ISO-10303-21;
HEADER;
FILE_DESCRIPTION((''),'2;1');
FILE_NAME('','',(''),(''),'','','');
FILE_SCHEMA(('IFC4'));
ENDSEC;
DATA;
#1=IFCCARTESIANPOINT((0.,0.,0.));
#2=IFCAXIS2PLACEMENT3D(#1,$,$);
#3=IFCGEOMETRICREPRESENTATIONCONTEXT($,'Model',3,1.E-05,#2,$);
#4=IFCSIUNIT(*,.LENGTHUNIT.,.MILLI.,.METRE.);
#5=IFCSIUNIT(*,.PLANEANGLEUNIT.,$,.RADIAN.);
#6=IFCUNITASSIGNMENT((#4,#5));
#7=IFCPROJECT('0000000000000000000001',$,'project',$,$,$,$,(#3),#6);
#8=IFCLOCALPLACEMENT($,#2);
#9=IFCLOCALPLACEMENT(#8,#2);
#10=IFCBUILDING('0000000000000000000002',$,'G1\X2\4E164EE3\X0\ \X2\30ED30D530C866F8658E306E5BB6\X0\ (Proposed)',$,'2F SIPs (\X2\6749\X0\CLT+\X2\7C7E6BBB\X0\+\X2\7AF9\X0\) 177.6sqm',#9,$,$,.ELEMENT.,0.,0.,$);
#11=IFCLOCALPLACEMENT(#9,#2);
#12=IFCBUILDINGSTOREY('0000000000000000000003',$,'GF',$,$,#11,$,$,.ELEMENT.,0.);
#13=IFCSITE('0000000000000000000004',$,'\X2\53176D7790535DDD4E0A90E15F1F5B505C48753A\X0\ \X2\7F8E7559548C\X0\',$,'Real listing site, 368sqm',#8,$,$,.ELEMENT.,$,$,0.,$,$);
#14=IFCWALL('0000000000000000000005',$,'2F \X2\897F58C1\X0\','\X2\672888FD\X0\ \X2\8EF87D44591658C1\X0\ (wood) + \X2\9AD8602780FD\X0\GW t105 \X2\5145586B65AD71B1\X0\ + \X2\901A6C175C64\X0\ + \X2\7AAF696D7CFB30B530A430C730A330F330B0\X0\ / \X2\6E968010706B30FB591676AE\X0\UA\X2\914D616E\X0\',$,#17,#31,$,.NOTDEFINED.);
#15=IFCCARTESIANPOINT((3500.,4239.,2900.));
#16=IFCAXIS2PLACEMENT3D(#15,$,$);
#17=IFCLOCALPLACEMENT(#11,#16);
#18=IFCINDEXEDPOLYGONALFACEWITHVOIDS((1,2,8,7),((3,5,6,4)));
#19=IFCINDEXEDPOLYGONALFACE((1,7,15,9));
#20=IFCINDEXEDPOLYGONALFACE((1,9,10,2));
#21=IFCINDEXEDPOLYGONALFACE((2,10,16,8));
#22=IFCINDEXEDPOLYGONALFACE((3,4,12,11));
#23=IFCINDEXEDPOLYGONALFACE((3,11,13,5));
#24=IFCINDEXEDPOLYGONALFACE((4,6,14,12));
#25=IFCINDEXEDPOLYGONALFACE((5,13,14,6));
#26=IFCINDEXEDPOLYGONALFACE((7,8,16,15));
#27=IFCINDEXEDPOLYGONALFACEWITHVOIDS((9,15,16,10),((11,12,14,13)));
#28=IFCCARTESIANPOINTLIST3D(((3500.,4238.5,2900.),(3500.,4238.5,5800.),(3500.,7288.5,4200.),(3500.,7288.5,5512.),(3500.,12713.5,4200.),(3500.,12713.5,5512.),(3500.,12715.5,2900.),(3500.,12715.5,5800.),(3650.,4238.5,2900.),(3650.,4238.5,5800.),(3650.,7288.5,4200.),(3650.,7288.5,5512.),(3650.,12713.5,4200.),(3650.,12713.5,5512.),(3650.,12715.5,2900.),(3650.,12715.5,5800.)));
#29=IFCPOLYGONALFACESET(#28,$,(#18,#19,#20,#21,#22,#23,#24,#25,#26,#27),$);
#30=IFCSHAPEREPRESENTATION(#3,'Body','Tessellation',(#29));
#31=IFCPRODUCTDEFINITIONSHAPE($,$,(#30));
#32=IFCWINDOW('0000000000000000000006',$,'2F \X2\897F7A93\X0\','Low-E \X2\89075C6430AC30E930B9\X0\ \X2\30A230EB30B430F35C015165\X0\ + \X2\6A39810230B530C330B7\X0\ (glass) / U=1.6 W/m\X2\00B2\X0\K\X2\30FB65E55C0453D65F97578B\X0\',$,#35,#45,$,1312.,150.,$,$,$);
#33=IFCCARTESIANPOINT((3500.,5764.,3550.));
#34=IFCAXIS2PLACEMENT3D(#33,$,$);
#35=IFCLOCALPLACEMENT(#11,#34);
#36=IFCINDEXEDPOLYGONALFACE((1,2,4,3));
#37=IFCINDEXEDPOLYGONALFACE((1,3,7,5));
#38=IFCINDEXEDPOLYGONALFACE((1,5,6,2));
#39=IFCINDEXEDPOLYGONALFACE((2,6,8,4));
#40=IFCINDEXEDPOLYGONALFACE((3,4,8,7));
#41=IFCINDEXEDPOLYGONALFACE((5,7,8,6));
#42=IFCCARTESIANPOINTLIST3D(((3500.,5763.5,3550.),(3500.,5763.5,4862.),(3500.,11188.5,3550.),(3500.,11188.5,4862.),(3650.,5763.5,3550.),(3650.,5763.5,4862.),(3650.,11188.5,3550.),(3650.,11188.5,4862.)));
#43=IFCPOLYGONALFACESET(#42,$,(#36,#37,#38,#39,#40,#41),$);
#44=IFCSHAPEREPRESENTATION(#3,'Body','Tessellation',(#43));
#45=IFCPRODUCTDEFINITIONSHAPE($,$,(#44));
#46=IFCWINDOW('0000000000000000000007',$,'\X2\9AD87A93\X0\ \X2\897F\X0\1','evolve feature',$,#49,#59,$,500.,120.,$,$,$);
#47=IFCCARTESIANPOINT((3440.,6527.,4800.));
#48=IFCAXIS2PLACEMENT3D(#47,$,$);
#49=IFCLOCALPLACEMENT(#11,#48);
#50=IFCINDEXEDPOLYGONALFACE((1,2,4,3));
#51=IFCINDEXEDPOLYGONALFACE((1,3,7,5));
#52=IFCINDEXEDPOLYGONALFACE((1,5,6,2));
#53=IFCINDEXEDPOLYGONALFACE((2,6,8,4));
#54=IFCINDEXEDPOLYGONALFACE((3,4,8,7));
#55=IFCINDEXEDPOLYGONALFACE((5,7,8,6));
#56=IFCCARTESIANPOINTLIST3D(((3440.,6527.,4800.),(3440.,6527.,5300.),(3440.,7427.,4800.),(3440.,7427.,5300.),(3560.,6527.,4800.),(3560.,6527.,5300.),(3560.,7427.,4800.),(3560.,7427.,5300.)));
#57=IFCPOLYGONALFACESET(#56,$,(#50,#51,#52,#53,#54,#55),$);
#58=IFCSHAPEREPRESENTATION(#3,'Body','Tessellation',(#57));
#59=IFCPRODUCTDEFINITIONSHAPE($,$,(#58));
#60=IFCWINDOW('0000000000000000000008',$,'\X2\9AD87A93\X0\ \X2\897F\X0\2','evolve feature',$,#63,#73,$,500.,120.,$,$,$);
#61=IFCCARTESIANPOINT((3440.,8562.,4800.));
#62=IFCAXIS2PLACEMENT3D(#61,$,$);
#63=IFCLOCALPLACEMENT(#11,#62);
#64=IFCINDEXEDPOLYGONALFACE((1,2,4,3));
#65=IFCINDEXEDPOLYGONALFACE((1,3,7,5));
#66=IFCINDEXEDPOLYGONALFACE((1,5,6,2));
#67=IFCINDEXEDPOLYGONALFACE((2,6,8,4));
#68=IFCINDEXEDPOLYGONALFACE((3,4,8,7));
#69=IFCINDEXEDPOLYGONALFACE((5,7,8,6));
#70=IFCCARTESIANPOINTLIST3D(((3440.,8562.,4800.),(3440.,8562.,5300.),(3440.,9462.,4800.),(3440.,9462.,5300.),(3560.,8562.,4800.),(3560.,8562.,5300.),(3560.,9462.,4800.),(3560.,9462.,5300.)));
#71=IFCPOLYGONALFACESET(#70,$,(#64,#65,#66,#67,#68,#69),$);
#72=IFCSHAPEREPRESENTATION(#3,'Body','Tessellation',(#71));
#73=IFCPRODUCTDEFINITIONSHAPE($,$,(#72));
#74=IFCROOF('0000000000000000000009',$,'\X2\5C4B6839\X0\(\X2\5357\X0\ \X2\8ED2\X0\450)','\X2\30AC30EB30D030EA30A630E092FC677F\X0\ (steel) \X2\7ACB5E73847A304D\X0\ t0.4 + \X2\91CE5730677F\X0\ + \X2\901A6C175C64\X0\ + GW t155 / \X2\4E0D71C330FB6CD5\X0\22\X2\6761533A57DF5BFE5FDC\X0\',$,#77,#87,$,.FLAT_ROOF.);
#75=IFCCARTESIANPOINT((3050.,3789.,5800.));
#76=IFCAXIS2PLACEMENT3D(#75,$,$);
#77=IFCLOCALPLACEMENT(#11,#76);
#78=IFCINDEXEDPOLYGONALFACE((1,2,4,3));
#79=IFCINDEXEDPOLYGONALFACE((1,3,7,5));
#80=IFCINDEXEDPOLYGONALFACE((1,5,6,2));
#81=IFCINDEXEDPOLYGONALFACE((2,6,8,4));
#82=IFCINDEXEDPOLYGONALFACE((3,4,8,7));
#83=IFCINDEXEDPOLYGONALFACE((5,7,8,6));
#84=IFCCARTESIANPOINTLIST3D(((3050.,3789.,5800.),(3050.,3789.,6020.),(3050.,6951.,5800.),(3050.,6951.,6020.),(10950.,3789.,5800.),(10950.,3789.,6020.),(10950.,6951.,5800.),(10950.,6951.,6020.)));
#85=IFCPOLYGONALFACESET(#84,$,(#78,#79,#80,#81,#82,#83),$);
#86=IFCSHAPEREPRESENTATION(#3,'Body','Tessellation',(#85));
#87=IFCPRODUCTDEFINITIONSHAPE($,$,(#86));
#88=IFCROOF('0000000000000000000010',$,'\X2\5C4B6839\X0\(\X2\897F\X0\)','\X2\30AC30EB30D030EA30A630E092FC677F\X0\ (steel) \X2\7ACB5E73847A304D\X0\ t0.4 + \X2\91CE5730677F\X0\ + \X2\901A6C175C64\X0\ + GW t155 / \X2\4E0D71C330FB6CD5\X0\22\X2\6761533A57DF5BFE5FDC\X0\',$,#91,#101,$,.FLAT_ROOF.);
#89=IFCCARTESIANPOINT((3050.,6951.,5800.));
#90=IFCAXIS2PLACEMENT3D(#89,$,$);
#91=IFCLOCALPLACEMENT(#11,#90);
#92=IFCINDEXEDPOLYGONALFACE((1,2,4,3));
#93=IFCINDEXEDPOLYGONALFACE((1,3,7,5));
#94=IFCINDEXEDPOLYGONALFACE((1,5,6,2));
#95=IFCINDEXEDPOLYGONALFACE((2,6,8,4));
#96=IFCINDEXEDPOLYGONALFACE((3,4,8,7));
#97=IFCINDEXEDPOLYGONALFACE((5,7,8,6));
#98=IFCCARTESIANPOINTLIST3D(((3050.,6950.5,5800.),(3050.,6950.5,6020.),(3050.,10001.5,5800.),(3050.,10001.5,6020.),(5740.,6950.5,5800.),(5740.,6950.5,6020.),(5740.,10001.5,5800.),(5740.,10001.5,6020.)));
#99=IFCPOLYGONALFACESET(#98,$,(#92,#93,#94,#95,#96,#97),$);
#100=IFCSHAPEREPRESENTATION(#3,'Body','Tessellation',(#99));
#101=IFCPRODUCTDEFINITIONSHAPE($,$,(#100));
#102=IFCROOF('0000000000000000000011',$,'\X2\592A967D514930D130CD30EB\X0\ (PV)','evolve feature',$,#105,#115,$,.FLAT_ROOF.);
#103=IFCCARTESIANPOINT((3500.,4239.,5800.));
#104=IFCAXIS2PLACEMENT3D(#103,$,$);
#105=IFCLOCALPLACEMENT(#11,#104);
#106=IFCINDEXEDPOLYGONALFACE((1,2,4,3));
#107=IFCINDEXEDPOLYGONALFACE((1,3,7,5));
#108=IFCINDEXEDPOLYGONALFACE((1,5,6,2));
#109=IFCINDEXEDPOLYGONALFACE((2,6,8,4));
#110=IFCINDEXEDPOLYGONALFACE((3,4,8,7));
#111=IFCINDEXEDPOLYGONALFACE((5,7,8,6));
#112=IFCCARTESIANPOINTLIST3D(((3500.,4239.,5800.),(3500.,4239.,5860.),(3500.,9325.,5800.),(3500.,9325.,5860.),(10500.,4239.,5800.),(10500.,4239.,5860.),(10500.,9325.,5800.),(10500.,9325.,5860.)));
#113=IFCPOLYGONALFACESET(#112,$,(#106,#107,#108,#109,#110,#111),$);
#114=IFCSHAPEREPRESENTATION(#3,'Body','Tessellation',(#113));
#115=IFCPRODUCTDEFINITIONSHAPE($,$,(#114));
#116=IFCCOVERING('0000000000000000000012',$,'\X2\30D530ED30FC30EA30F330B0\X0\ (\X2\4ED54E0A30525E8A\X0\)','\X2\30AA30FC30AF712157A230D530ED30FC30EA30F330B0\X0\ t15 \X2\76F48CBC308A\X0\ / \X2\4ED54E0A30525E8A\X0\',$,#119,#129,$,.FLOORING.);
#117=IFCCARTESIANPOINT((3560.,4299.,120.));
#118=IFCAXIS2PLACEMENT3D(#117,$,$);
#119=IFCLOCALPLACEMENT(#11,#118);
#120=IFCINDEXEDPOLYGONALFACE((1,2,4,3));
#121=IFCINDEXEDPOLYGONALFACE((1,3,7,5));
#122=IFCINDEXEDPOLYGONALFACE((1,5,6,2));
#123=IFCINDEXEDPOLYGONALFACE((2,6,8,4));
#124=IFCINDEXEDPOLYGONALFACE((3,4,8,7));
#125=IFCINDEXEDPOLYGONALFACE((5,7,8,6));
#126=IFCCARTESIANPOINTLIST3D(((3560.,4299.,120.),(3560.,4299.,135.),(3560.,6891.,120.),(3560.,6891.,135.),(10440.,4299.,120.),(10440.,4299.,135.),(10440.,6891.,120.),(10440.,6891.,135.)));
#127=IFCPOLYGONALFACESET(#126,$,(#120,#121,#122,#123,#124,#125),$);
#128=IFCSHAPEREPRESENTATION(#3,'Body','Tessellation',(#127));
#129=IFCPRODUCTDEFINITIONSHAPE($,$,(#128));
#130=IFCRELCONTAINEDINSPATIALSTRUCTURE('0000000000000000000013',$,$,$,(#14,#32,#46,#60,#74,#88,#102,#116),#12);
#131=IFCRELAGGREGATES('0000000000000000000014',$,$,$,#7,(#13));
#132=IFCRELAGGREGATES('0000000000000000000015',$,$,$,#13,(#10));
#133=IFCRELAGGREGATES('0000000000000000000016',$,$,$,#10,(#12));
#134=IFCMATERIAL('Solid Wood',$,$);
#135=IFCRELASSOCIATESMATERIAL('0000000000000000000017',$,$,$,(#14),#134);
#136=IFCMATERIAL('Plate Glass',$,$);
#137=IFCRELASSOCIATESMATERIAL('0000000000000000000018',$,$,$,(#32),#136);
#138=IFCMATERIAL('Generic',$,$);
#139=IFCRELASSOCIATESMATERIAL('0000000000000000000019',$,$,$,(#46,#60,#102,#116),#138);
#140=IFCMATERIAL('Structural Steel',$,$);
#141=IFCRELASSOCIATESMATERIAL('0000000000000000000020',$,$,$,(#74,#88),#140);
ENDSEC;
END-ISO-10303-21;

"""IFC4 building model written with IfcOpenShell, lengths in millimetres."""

from ifc_helpers import new_model, si_unit, frame, frame_2d, origin, place, context, project, spatial, rectangle, extrude, material, element, fill, save


model = new_model("IFC4")

# Units and contexts
model_context = context("Model", 3, precision=1e-05, world=origin())
ifc_project = project(units=[si_unit("LENGTHUNIT", "METRE", prefix="MILLI"), si_unit("PLANEANGLEUNIT", "RADIAN")], contexts=[model_context])

# Site, building, storey
site_placement = place(None, origin())
site = spatial("IfcSite", under=ifc_project, at=site_placement, Name="北海道川上郡弟子屈町 美留和", ObjectType="Real listing site, 368sqm", CompositionType="ELEMENT", RefElevation=0.0)
building_placement = place(site_placement, origin())
building = spatial("IfcBuilding", under=site, at=building_placement, Name="G1世代 ロフト書斎の家 (Proposed)", ObjectType="2F SIPs (杉CLT+籾殻+竹) 177.6sqm", CompositionType="ELEMENT", ElevationOfRefHeight=0.0, ElevationOfTerrain=0.0)
storey_placement = place(building_placement, origin())
storey = spatial("IfcBuildingStorey", under=building, at=storey_placement, Name="GF", CompositionType="ELEMENT", Elevation=0.0)

# Shared definitions
ifc_material_1 = material(Name="Solid Wood")
ifc_material_2 = material(Name="Generic")

# Shared definitions
ifc_material_3 = material(Name="Plate Glass")

# Wall, openings, windows
wall_1_placement = place(storey_placement, frame((3500.0, 4239.0, 2900.0)))
wall_1 = element("IfcWall", 1, at=wall_1_placement, inside=storey, material=ifc_material_1, Name="2F 西壁", Description="木製 軸組外壁 (wood) + 高性能GW t105 充填断熱 + 通気層 + 窯業系サイディング / 準耐火・外皮UA配慮", PredefinedType="NOTDEFINED", context=model_context, shape_type="SweptSolid", body=[
    extrude(rectangle(XDim=150.0, YDim=8477.0, at=frame_2d((75.0, 4238.0))), frame((3500.0, 4239.0, 2900.0)), (0.0, 0.0, 1.0), 2900.0),
])
opening_1_placement = place(storey_placement, frame((3500.0, 5764.0, 3550.0)))
opening_1 = element("IfcOpeningElement", 2, at=opening_1_placement, cuts=wall_1, PredefinedType="NOTDEFINED", context=model_context, shape_type="SweptSolid", body=[
    extrude(rectangle(XDim=150.0, YDim=5425.0, at=frame_2d((75.0, 2712.0))), frame((3500.0, 5764.0, 3550.0)), (0.0, 0.0, 1.0), 1312.0),
])
opening_2_placement = place(storey_placement, frame((3440.0, 6527.0, 4800.0)))
opening_2 = element("IfcOpeningElement", 3, at=opening_2_placement, cuts=wall_1, PredefinedType="NOTDEFINED", context=model_context, shape_type="SweptSolid", body=[
    extrude(rectangle(XDim=120.0, YDim=900.0, at=frame_2d((60.0, 450.0))), frame((3440.0, 6527.0, 4800.0)), (0.0, 0.0, 1.0), 500.0),
])
opening_3_placement = place(storey_placement, frame((3440.0, 8562.0, 4800.0)))
opening_3 = element("IfcOpeningElement", 4, at=opening_3_placement, cuts=wall_1, PredefinedType="NOTDEFINED", context=model_context, shape_type="SweptSolid", body=[
    extrude(rectangle(XDim=120.0, YDim=900.0, at=frame_2d((60.0, 450.0))), frame((3440.0, 8562.0, 4800.0)), (0.0, 0.0, 1.0), 500.0),
])
window_1_placement = place(storey_placement, frame((3500.0, 5764.0, 3550.0)))
window_1 = element("IfcWindow", 5, at=window_1_placement, inside=storey, material=ifc_material_3, Name="2F 西窓", Description="Low-E 複層ガラス アルゴン封入 + 樹脂サッシ (glass) / U=1.6 W/m²K・日射取得型", OverallHeight=1312.0, OverallWidth=150.0, context=model_context, shape_type="SweptSolid", body=[
    extrude(rectangle(XDim=150.0, YDim=5425.0, at=frame_2d((75.0, 2712.0))), frame((3500.0, 5764.0, 3550.0)), (0.0, 0.0, 1.0), 1312.0),
])
fill(opening_1, window_1)
window_2_placement = place(storey_placement, frame((3440.0, 6527.0, 4800.0)))
window_2 = element("IfcWindow", 6, at=window_2_placement, inside=storey, material=ifc_material_2, Name="高窓 西1", Description="evolve feature", OverallHeight=500.0, OverallWidth=120.0, context=model_context, shape_type="SweptSolid", body=[
    extrude(rectangle(XDim=120.0, YDim=900.0, at=frame_2d((60.0, 450.0))), frame((3440.0, 6527.0, 4800.0)), (0.0, 0.0, 1.0), 500.0),
])
fill(opening_2, window_2)
window_3_placement = place(storey_placement, frame((3440.0, 8562.0, 4800.0)))
window_3 = element("IfcWindow", 7, at=window_3_placement, inside=storey, material=ifc_material_2, Name="高窓 西2", Description="evolve feature", OverallHeight=500.0, OverallWidth=120.0, context=model_context, shape_type="SweptSolid", body=[
    extrude(rectangle(XDim=120.0, YDim=900.0, at=frame_2d((60.0, 450.0))), frame((3440.0, 8562.0, 4800.0)), (0.0, 0.0, 1.0), 500.0),
])
fill(opening_3, window_3)

# Roofs
ifc_material_4 = material(Name="Structural Steel")
roof_1_placement = place(storey_placement, frame((3050.0, 3789.0, 5800.0)))
element("IfcRoof", 8, at=roof_1_placement, inside=storey, material=ifc_material_4, Name="屋根(南 軒450)", Description="ガルバリウム鋼板 (steel) 立平葺き t0.4 + 野地板 + 通気層 + GW t155 / 不燃・法22条区域対応", PredefinedType="FLAT_ROOF", context=model_context, shape_type="SweptSolid", body=[
    extrude(rectangle(XDim=7900.0, YDim=3162.0, at=frame_2d((3950.0, 1581.0))), frame((3050.0, 3789.0, 5800.0)), (0.0, 0.0, 1.0), 220.0),
])
roof_2_placement = place(storey_placement, frame((3050.0, 6951.0, 5800.0)))
element("IfcRoof", 9, at=roof_2_placement, inside=storey, material=ifc_material_4, Name="屋根(西)", Description="ガルバリウム鋼板 (steel) 立平葺き t0.4 + 野地板 + 通気層 + GW t155 / 不燃・法22条区域対応", PredefinedType="FLAT_ROOF", context=model_context, shape_type="SweptSolid", body=[
    extrude(rectangle(XDim=2690.0, YDim=3051.0, at=frame_2d((1345.0, 1525.0))), frame((3050.0, 6951.0, 5800.0)), (0.0, 0.0, 1.0), 220.0),
])
roof_3_placement = place(storey_placement, frame((3500.0, 4239.0, 5800.0)))
element("IfcRoof", 10, at=roof_3_placement, inside=storey, material=ifc_material_2, Name="太陽光パネル (PV)", Description="evolve feature", PredefinedType="FLAT_ROOF", context=model_context, shape_type="SweptSolid", body=[
    extrude(rectangle(XDim=7000.0, YDim=5086.0, at=frame_2d((3500.0, 2543.0))), frame((3500.0, 4239.0, 5800.0)), (0.0, 0.0, 1.0), 60.0),
])

# Covering
covering_placement = place(storey_placement, frame((3560.0, 4299.0, 120.0)))
element("IfcCovering", 11, at=covering_placement, inside=storey, material=ifc_material_2, Name="フローリング (仕上げ床)", Description="オーク無垢フローリング t15 直貼り / 仕上げ床", PredefinedType="FLOORING", context=model_context, shape_type="SweptSolid", body=[
    extrude(rectangle(XDim=6880.0, YDim=2592.0, at=frame_2d((3440.0, 1296.0))), frame((3560.0, 4299.0, 120.0)), (0.0, 0.0, 1.0), 15.0),
])

save(model, "model.ifc")
